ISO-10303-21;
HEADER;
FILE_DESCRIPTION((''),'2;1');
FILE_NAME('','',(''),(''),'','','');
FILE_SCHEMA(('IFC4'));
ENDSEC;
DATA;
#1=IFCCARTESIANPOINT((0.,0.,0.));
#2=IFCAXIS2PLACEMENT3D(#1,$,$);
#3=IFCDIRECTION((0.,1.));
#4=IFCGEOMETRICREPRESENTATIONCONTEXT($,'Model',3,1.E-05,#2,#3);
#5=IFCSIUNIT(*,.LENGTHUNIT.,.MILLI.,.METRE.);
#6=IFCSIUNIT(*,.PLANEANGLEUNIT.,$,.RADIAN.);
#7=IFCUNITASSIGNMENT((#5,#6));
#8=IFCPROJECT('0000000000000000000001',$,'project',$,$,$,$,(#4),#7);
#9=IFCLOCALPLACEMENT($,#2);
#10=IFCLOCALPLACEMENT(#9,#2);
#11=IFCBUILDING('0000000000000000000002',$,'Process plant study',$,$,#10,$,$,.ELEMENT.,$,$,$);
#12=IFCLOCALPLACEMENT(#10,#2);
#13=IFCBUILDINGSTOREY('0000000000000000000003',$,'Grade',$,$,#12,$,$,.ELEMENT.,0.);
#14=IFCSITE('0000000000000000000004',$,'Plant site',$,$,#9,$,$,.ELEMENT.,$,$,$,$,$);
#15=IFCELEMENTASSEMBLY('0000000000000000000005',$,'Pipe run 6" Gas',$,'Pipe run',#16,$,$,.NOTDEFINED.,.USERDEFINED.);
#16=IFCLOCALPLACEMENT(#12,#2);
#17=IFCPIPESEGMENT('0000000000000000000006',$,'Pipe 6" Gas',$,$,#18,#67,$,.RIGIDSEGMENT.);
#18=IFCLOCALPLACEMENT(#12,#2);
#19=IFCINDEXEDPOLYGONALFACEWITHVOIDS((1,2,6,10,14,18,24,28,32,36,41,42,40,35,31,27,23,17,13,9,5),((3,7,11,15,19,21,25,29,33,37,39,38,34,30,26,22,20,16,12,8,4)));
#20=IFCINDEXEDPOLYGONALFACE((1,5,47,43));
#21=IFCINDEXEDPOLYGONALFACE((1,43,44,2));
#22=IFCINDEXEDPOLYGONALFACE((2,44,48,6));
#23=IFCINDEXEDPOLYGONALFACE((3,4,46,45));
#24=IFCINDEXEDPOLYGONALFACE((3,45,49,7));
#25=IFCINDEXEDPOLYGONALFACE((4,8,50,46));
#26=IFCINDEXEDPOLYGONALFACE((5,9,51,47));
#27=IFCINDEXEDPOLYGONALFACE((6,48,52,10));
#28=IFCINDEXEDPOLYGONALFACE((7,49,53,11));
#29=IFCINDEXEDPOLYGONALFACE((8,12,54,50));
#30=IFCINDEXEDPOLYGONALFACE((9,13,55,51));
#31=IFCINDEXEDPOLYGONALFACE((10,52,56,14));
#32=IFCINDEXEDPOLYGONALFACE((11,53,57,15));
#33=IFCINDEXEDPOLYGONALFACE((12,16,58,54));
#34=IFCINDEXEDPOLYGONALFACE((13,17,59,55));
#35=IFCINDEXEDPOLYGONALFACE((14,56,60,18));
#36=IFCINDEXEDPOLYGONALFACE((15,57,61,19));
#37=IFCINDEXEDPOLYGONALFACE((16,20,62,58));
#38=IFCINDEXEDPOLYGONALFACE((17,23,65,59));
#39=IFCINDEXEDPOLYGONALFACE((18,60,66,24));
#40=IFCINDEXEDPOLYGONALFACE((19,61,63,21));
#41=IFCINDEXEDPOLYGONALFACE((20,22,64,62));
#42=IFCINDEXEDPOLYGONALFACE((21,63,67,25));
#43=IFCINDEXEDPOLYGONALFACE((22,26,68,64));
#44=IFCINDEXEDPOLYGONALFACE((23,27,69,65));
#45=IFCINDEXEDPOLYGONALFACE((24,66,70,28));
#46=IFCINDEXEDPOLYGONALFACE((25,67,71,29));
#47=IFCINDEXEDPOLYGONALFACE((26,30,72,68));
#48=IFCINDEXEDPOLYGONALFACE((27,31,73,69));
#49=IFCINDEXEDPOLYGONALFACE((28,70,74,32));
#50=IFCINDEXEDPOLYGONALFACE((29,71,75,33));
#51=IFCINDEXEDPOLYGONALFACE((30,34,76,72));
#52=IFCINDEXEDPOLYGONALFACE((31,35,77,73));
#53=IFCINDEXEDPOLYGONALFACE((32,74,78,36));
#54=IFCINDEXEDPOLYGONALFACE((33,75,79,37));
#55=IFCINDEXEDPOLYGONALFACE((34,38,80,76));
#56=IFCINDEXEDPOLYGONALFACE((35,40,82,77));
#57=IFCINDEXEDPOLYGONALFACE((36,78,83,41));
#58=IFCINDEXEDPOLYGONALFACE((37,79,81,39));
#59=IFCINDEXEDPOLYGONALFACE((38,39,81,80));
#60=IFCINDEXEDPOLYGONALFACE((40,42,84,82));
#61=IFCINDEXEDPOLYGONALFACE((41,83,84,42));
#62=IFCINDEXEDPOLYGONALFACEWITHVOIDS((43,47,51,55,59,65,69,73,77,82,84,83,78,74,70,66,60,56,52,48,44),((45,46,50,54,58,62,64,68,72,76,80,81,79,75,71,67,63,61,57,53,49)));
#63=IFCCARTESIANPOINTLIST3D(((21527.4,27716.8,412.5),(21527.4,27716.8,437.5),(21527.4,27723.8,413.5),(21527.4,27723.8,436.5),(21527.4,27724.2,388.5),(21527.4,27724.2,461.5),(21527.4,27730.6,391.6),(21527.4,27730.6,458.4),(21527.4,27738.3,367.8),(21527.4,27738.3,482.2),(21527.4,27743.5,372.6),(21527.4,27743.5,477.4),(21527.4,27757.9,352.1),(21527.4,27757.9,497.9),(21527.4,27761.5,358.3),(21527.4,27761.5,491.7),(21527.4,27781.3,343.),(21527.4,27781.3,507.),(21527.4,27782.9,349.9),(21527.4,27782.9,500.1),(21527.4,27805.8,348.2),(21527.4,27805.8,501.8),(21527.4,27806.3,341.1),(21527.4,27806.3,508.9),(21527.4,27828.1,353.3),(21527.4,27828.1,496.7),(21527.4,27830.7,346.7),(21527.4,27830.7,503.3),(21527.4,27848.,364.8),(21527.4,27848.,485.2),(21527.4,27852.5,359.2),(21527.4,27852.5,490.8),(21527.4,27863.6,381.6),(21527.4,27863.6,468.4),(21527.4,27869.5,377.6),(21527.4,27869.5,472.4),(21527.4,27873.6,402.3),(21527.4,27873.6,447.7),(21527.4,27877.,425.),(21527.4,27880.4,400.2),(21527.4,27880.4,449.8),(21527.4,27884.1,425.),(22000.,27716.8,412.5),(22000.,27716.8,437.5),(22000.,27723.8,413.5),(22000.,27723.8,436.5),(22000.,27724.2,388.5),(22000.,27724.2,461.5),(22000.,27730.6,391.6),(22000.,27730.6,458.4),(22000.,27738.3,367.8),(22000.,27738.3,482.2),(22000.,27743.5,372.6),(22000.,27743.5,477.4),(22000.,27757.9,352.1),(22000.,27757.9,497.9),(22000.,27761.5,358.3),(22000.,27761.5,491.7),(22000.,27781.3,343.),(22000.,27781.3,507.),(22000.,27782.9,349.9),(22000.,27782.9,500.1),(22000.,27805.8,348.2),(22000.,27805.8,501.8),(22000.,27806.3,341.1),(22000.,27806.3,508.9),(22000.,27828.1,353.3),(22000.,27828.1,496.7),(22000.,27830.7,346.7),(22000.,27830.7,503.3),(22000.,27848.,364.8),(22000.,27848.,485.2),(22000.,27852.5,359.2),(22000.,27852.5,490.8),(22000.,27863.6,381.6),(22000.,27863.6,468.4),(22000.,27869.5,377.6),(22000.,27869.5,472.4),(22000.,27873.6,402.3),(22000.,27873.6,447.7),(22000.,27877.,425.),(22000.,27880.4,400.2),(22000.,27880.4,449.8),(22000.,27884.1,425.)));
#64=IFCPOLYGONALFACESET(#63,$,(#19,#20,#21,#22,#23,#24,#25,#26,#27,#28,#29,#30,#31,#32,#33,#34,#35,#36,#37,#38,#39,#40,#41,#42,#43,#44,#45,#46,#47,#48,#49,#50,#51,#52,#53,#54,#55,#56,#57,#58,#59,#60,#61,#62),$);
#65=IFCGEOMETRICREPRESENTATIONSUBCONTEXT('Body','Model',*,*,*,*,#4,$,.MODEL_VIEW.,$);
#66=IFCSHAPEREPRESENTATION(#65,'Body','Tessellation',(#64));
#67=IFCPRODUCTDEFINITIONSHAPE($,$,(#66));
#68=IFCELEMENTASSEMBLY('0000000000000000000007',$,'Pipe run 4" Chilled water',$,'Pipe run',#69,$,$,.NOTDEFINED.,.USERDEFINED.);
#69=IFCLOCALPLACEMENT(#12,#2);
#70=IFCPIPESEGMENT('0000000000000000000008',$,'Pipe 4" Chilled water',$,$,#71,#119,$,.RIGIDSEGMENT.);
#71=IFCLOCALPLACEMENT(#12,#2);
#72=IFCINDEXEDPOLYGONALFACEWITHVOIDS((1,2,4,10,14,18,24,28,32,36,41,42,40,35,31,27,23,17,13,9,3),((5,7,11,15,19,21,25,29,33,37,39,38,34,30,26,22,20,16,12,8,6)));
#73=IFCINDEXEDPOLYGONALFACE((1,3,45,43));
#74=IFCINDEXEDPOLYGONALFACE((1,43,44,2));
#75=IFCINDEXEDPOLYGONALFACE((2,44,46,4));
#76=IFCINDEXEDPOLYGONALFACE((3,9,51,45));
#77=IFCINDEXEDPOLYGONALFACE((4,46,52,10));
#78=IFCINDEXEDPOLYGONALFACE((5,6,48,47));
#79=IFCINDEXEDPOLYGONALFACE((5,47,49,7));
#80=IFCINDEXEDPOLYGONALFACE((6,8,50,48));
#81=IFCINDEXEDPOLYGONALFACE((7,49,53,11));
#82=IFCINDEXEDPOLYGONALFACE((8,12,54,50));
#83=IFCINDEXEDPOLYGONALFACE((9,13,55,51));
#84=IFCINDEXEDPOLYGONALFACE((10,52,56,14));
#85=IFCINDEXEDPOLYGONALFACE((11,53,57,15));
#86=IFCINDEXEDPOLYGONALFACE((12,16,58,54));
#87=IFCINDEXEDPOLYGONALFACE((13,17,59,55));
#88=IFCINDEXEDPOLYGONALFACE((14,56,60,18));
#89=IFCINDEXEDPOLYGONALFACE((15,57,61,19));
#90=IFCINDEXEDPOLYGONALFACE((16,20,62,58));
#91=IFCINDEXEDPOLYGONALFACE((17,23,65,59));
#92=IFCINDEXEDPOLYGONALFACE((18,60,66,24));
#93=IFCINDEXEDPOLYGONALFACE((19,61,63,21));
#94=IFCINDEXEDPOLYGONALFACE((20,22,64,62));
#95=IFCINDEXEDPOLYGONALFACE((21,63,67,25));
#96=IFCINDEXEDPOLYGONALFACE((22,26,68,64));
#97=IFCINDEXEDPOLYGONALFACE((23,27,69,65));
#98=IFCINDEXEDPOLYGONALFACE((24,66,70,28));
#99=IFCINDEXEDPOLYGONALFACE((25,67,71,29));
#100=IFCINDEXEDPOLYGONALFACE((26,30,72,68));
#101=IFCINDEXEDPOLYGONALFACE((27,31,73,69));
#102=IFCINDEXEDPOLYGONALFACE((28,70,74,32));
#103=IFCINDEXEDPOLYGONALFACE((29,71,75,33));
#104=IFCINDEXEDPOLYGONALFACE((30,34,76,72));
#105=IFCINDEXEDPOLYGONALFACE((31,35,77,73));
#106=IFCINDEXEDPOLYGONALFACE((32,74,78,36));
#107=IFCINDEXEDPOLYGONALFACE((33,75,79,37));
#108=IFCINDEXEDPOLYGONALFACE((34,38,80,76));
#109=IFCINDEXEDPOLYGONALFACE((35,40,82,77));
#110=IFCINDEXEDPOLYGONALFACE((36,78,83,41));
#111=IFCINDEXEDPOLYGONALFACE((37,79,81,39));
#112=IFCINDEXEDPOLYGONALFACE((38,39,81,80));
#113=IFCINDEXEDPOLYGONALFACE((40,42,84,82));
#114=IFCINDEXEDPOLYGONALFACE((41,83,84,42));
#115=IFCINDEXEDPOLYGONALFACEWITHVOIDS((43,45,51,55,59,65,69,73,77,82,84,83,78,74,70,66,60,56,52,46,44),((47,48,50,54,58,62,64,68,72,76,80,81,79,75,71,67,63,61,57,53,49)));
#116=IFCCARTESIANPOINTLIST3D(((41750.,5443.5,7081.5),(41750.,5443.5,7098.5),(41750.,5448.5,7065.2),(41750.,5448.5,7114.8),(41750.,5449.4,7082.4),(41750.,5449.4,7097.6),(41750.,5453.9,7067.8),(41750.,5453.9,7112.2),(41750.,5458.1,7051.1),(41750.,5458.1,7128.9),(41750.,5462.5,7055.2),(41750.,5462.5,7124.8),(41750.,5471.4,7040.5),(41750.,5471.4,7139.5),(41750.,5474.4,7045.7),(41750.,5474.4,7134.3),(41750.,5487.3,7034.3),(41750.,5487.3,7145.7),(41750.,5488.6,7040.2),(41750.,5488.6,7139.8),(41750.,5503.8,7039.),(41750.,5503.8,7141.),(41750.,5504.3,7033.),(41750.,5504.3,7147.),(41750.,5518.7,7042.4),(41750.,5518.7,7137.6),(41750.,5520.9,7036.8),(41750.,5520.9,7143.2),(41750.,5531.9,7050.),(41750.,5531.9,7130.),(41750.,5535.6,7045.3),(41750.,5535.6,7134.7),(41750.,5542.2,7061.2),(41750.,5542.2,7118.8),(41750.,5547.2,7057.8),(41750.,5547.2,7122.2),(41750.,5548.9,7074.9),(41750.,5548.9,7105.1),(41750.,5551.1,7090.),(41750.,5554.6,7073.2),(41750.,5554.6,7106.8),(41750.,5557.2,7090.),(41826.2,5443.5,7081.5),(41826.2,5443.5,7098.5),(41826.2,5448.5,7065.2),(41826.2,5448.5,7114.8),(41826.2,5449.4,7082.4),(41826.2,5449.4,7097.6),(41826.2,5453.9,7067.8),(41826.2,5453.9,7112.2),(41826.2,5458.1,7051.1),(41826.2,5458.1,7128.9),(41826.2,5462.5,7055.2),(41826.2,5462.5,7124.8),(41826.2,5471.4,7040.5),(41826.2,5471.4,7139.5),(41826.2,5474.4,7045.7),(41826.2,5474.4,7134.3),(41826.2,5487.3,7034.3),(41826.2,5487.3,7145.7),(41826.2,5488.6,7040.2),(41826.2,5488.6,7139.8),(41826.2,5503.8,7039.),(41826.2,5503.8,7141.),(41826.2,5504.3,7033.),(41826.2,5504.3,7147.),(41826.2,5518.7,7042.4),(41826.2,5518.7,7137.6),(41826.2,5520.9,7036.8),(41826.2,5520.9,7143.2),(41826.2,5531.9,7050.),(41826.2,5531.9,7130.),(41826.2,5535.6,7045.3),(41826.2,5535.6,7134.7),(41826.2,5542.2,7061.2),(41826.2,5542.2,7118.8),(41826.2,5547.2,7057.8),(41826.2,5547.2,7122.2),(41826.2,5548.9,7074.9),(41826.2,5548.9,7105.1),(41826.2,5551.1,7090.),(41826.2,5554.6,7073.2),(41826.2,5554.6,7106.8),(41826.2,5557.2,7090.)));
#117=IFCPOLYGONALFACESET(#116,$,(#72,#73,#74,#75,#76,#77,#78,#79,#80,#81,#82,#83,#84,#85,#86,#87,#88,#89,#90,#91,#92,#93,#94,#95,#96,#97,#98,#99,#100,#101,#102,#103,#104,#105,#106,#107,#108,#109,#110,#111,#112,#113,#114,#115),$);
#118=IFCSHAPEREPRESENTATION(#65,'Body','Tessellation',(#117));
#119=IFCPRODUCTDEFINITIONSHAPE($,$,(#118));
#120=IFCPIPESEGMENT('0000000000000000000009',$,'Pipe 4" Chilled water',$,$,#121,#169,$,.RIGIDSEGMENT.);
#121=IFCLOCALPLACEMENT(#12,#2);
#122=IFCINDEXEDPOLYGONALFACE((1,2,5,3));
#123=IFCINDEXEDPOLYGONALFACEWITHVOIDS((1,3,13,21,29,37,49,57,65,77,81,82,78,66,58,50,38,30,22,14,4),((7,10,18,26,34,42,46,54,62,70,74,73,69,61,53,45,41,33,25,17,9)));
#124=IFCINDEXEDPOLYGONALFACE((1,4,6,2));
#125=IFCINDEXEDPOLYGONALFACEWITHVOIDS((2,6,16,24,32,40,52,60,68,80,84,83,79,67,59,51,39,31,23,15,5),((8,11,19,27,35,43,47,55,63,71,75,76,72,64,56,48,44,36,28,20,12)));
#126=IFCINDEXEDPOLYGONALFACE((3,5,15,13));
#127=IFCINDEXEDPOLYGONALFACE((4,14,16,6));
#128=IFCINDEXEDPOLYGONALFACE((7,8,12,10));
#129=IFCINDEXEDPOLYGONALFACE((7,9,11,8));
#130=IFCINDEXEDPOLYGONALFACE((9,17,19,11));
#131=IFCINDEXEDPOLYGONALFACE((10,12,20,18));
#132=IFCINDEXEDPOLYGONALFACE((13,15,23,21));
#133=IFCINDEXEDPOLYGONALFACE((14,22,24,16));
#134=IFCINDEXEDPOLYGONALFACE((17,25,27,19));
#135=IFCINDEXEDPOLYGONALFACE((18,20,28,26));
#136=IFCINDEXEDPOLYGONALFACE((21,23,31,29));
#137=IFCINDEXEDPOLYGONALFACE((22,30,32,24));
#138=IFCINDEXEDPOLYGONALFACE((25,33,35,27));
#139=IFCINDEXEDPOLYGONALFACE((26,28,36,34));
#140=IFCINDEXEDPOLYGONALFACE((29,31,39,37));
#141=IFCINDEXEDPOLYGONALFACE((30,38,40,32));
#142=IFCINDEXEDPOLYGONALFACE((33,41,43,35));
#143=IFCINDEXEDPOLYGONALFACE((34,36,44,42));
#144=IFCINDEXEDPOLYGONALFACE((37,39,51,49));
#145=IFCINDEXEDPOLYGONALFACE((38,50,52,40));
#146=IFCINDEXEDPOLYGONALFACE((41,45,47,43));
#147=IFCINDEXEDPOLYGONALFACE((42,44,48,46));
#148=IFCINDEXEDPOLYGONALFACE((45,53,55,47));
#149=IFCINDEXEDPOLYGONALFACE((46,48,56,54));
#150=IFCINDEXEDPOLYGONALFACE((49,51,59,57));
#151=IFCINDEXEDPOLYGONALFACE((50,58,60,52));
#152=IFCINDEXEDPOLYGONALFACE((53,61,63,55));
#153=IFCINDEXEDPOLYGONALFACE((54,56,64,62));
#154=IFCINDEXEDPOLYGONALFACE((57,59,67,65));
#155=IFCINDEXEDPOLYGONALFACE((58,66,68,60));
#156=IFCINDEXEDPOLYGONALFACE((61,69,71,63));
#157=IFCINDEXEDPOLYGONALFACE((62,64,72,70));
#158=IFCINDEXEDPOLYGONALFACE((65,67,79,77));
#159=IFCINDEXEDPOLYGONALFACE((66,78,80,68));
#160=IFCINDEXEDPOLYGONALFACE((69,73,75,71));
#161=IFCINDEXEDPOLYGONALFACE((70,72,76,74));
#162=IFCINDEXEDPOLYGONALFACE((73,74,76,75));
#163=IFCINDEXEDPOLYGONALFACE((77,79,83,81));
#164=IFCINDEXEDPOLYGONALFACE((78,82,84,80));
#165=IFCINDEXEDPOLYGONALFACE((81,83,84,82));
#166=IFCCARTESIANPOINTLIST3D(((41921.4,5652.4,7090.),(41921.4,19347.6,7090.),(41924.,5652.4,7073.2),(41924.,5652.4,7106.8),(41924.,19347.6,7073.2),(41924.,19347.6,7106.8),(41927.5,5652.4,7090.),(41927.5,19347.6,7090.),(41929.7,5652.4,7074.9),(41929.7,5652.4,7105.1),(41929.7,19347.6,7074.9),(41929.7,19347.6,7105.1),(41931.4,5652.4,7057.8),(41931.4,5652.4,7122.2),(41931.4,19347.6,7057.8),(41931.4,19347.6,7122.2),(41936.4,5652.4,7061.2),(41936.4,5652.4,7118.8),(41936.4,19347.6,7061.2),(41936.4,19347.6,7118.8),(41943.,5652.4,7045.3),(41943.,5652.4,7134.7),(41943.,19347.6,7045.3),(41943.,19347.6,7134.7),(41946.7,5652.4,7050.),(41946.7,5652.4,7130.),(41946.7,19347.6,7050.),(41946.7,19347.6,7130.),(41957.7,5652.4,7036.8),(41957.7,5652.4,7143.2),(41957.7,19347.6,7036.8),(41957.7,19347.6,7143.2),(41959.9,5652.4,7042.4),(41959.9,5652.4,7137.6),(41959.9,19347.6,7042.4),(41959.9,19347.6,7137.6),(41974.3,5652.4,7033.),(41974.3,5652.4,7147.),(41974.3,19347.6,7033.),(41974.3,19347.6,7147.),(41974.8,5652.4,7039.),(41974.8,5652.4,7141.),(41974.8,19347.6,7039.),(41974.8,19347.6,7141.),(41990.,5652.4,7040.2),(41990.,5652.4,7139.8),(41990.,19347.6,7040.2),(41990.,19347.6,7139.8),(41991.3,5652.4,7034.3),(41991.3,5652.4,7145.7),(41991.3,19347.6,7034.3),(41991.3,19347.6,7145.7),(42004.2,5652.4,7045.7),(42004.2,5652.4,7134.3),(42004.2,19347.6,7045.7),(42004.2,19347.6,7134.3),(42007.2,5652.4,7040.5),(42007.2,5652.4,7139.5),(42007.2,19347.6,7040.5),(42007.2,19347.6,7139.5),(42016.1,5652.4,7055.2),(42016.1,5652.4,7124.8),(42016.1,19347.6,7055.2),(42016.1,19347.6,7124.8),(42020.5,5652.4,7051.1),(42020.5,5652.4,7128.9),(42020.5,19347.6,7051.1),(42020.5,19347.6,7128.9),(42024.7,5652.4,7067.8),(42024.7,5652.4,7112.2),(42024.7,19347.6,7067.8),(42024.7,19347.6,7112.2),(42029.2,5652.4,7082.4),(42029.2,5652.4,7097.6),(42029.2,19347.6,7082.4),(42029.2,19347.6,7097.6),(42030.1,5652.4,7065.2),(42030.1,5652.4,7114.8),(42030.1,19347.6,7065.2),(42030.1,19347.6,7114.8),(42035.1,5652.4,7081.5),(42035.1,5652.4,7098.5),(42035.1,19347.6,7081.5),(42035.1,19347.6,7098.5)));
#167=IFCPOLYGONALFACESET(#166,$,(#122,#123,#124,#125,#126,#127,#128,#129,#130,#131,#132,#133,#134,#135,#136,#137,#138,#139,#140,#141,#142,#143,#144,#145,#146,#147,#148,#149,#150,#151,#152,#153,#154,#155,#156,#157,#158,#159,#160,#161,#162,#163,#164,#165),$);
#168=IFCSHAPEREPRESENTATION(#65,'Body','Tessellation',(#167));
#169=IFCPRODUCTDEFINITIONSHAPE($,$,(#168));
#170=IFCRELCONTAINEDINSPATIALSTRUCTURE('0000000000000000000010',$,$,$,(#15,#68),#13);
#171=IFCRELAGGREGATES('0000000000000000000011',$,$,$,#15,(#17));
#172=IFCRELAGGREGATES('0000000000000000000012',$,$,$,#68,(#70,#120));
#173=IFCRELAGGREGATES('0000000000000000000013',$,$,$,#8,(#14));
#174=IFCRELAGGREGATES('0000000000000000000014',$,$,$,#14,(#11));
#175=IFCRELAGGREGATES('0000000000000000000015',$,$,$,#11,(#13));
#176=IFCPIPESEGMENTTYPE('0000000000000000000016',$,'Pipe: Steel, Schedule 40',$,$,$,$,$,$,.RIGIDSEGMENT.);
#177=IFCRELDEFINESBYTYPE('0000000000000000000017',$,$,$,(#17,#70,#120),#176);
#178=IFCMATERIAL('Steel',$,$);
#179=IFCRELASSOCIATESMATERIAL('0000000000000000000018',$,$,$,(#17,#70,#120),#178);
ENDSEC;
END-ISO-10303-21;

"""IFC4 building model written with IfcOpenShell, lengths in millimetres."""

from ifc_helpers import new_model, si_unit, direction, frame, origin, origin_with_axes, origin_2d, place, context, subcontext, project, spatial, hollow_circle, extrude, material, type_object, element, aggregate, save


model = new_model("IFC4")

# Units and contexts
model_context = context("Model", 3, precision=1e-05, world=origin(), true_north=direction((0.0, 1.0)))
body_context = subcontext(model_context, "Body", "Model", "MODEL_VIEW")
ifc_project = project(units=[si_unit("LENGTHUNIT", "METRE", prefix="MILLI"), si_unit("PLANEANGLEUNIT", "RADIAN")], contexts=[model_context])

# Site, building, storey
site_placement = place(None, origin())
site = spatial("IfcSite", under=ifc_project, at=site_placement, Name="Plant site", CompositionType="ELEMENT")
building_placement = place(site_placement, origin())
building = spatial("IfcBuilding", under=site, at=building_placement, Name="Process plant study", CompositionType="ELEMENT")
storey_placement = place(building_placement, origin())
storey = spatial("IfcBuildingStorey", under=building, at=storey_placement, Name="Grade", CompositionType="ELEMENT", Elevation=0.0)

# Element assembly, pipe segment
assembly_1_placement = place(storey_placement, origin_with_axes())
assembly_1 = element("IfcElementAssembly", 1, at=assembly_1_placement, inside=storey, Name="Pipe run 6\" Gas", ObjectType="Pipe run", AssemblyPlace="NOTDEFINED", PredefinedType="USERDEFINED")
ifc_material = material(Name="Steel")
pipe_segment_type = type_object("IfcPipeSegmentType", Name="Pipe: Steel, Schedule 40", PredefinedType="RIGIDSEGMENT")
pipe_segment_1_placement = place(storey_placement, origin_with_axes())
pipe_segment_1 = element("IfcPipeSegment", 2, at=pipe_segment_1_placement, type_object=pipe_segment_type, material=ifc_material, Name="Pipe 6\" Gas", PredefinedType="RIGIDSEGMENT", context=body_context, shape_type="SweptSolid", body=[
    extrude(hollow_circle(Radius=84.1, WallThickness=7.1, at=origin_2d()), frame((21527.4, 27800.0, 425.0), z_axis=(1.0, 0.0, 0.0), x_axis=(0.0, 1.0, 0.0)), (0.0, 0.0, 1.0), 472.6),
])

# Element assembly, pipe segments
assembly_2_placement = place(storey_placement, origin_with_axes())
assembly_2 = element("IfcElementAssembly", 3, at=assembly_2_placement, inside=storey, Name="Pipe run 4\" Chilled water", ObjectType="Pipe run", AssemblyPlace="NOTDEFINED", PredefinedType="USERDEFINED")
pipe_segment_2_placement = place(storey_placement, origin_with_axes())
pipe_segment_2 = element("IfcPipeSegment", 4, at=pipe_segment_2_placement, type_object=pipe_segment_type, material=ifc_material, Name="Pipe 4\" Chilled water", PredefinedType="RIGIDSEGMENT", context=body_context, shape_type="SweptSolid", body=[
    extrude(hollow_circle(Radius=57.1, WallThickness=6.0, at=origin_2d()), frame((41750.0, 5500.0, 7090.0), z_axis=(1.0, 0.0, 0.0), x_axis=(0.0, 1.0, 0.0)), (0.0, 0.0, 1.0), 76.2),
])
pipe_segment_3_placement = place(storey_placement, origin_with_axes())
pipe_segment_3 = element("IfcPipeSegment", 5, at=pipe_segment_3_placement, type_object=pipe_segment_type, material=ifc_material, Name="Pipe 4\" Chilled water", PredefinedType="RIGIDSEGMENT", context=body_context, shape_type="SweptSolid", body=[
    extrude(hollow_circle(Radius=57.1, WallThickness=6.0, at=origin_2d()), frame((41978.6, 5652.4, 7090.0), z_axis=(0.0, 1.0, 0.0), x_axis=(-1.0, 0.0, 0.0)), (0.0, 0.0, 1.0), 13695.2),
])

aggregate(assembly_1, [pipe_segment_1])
aggregate(assembly_2, [pipe_segment_2, pipe_segment_3])

save(model, "model.ifc")
